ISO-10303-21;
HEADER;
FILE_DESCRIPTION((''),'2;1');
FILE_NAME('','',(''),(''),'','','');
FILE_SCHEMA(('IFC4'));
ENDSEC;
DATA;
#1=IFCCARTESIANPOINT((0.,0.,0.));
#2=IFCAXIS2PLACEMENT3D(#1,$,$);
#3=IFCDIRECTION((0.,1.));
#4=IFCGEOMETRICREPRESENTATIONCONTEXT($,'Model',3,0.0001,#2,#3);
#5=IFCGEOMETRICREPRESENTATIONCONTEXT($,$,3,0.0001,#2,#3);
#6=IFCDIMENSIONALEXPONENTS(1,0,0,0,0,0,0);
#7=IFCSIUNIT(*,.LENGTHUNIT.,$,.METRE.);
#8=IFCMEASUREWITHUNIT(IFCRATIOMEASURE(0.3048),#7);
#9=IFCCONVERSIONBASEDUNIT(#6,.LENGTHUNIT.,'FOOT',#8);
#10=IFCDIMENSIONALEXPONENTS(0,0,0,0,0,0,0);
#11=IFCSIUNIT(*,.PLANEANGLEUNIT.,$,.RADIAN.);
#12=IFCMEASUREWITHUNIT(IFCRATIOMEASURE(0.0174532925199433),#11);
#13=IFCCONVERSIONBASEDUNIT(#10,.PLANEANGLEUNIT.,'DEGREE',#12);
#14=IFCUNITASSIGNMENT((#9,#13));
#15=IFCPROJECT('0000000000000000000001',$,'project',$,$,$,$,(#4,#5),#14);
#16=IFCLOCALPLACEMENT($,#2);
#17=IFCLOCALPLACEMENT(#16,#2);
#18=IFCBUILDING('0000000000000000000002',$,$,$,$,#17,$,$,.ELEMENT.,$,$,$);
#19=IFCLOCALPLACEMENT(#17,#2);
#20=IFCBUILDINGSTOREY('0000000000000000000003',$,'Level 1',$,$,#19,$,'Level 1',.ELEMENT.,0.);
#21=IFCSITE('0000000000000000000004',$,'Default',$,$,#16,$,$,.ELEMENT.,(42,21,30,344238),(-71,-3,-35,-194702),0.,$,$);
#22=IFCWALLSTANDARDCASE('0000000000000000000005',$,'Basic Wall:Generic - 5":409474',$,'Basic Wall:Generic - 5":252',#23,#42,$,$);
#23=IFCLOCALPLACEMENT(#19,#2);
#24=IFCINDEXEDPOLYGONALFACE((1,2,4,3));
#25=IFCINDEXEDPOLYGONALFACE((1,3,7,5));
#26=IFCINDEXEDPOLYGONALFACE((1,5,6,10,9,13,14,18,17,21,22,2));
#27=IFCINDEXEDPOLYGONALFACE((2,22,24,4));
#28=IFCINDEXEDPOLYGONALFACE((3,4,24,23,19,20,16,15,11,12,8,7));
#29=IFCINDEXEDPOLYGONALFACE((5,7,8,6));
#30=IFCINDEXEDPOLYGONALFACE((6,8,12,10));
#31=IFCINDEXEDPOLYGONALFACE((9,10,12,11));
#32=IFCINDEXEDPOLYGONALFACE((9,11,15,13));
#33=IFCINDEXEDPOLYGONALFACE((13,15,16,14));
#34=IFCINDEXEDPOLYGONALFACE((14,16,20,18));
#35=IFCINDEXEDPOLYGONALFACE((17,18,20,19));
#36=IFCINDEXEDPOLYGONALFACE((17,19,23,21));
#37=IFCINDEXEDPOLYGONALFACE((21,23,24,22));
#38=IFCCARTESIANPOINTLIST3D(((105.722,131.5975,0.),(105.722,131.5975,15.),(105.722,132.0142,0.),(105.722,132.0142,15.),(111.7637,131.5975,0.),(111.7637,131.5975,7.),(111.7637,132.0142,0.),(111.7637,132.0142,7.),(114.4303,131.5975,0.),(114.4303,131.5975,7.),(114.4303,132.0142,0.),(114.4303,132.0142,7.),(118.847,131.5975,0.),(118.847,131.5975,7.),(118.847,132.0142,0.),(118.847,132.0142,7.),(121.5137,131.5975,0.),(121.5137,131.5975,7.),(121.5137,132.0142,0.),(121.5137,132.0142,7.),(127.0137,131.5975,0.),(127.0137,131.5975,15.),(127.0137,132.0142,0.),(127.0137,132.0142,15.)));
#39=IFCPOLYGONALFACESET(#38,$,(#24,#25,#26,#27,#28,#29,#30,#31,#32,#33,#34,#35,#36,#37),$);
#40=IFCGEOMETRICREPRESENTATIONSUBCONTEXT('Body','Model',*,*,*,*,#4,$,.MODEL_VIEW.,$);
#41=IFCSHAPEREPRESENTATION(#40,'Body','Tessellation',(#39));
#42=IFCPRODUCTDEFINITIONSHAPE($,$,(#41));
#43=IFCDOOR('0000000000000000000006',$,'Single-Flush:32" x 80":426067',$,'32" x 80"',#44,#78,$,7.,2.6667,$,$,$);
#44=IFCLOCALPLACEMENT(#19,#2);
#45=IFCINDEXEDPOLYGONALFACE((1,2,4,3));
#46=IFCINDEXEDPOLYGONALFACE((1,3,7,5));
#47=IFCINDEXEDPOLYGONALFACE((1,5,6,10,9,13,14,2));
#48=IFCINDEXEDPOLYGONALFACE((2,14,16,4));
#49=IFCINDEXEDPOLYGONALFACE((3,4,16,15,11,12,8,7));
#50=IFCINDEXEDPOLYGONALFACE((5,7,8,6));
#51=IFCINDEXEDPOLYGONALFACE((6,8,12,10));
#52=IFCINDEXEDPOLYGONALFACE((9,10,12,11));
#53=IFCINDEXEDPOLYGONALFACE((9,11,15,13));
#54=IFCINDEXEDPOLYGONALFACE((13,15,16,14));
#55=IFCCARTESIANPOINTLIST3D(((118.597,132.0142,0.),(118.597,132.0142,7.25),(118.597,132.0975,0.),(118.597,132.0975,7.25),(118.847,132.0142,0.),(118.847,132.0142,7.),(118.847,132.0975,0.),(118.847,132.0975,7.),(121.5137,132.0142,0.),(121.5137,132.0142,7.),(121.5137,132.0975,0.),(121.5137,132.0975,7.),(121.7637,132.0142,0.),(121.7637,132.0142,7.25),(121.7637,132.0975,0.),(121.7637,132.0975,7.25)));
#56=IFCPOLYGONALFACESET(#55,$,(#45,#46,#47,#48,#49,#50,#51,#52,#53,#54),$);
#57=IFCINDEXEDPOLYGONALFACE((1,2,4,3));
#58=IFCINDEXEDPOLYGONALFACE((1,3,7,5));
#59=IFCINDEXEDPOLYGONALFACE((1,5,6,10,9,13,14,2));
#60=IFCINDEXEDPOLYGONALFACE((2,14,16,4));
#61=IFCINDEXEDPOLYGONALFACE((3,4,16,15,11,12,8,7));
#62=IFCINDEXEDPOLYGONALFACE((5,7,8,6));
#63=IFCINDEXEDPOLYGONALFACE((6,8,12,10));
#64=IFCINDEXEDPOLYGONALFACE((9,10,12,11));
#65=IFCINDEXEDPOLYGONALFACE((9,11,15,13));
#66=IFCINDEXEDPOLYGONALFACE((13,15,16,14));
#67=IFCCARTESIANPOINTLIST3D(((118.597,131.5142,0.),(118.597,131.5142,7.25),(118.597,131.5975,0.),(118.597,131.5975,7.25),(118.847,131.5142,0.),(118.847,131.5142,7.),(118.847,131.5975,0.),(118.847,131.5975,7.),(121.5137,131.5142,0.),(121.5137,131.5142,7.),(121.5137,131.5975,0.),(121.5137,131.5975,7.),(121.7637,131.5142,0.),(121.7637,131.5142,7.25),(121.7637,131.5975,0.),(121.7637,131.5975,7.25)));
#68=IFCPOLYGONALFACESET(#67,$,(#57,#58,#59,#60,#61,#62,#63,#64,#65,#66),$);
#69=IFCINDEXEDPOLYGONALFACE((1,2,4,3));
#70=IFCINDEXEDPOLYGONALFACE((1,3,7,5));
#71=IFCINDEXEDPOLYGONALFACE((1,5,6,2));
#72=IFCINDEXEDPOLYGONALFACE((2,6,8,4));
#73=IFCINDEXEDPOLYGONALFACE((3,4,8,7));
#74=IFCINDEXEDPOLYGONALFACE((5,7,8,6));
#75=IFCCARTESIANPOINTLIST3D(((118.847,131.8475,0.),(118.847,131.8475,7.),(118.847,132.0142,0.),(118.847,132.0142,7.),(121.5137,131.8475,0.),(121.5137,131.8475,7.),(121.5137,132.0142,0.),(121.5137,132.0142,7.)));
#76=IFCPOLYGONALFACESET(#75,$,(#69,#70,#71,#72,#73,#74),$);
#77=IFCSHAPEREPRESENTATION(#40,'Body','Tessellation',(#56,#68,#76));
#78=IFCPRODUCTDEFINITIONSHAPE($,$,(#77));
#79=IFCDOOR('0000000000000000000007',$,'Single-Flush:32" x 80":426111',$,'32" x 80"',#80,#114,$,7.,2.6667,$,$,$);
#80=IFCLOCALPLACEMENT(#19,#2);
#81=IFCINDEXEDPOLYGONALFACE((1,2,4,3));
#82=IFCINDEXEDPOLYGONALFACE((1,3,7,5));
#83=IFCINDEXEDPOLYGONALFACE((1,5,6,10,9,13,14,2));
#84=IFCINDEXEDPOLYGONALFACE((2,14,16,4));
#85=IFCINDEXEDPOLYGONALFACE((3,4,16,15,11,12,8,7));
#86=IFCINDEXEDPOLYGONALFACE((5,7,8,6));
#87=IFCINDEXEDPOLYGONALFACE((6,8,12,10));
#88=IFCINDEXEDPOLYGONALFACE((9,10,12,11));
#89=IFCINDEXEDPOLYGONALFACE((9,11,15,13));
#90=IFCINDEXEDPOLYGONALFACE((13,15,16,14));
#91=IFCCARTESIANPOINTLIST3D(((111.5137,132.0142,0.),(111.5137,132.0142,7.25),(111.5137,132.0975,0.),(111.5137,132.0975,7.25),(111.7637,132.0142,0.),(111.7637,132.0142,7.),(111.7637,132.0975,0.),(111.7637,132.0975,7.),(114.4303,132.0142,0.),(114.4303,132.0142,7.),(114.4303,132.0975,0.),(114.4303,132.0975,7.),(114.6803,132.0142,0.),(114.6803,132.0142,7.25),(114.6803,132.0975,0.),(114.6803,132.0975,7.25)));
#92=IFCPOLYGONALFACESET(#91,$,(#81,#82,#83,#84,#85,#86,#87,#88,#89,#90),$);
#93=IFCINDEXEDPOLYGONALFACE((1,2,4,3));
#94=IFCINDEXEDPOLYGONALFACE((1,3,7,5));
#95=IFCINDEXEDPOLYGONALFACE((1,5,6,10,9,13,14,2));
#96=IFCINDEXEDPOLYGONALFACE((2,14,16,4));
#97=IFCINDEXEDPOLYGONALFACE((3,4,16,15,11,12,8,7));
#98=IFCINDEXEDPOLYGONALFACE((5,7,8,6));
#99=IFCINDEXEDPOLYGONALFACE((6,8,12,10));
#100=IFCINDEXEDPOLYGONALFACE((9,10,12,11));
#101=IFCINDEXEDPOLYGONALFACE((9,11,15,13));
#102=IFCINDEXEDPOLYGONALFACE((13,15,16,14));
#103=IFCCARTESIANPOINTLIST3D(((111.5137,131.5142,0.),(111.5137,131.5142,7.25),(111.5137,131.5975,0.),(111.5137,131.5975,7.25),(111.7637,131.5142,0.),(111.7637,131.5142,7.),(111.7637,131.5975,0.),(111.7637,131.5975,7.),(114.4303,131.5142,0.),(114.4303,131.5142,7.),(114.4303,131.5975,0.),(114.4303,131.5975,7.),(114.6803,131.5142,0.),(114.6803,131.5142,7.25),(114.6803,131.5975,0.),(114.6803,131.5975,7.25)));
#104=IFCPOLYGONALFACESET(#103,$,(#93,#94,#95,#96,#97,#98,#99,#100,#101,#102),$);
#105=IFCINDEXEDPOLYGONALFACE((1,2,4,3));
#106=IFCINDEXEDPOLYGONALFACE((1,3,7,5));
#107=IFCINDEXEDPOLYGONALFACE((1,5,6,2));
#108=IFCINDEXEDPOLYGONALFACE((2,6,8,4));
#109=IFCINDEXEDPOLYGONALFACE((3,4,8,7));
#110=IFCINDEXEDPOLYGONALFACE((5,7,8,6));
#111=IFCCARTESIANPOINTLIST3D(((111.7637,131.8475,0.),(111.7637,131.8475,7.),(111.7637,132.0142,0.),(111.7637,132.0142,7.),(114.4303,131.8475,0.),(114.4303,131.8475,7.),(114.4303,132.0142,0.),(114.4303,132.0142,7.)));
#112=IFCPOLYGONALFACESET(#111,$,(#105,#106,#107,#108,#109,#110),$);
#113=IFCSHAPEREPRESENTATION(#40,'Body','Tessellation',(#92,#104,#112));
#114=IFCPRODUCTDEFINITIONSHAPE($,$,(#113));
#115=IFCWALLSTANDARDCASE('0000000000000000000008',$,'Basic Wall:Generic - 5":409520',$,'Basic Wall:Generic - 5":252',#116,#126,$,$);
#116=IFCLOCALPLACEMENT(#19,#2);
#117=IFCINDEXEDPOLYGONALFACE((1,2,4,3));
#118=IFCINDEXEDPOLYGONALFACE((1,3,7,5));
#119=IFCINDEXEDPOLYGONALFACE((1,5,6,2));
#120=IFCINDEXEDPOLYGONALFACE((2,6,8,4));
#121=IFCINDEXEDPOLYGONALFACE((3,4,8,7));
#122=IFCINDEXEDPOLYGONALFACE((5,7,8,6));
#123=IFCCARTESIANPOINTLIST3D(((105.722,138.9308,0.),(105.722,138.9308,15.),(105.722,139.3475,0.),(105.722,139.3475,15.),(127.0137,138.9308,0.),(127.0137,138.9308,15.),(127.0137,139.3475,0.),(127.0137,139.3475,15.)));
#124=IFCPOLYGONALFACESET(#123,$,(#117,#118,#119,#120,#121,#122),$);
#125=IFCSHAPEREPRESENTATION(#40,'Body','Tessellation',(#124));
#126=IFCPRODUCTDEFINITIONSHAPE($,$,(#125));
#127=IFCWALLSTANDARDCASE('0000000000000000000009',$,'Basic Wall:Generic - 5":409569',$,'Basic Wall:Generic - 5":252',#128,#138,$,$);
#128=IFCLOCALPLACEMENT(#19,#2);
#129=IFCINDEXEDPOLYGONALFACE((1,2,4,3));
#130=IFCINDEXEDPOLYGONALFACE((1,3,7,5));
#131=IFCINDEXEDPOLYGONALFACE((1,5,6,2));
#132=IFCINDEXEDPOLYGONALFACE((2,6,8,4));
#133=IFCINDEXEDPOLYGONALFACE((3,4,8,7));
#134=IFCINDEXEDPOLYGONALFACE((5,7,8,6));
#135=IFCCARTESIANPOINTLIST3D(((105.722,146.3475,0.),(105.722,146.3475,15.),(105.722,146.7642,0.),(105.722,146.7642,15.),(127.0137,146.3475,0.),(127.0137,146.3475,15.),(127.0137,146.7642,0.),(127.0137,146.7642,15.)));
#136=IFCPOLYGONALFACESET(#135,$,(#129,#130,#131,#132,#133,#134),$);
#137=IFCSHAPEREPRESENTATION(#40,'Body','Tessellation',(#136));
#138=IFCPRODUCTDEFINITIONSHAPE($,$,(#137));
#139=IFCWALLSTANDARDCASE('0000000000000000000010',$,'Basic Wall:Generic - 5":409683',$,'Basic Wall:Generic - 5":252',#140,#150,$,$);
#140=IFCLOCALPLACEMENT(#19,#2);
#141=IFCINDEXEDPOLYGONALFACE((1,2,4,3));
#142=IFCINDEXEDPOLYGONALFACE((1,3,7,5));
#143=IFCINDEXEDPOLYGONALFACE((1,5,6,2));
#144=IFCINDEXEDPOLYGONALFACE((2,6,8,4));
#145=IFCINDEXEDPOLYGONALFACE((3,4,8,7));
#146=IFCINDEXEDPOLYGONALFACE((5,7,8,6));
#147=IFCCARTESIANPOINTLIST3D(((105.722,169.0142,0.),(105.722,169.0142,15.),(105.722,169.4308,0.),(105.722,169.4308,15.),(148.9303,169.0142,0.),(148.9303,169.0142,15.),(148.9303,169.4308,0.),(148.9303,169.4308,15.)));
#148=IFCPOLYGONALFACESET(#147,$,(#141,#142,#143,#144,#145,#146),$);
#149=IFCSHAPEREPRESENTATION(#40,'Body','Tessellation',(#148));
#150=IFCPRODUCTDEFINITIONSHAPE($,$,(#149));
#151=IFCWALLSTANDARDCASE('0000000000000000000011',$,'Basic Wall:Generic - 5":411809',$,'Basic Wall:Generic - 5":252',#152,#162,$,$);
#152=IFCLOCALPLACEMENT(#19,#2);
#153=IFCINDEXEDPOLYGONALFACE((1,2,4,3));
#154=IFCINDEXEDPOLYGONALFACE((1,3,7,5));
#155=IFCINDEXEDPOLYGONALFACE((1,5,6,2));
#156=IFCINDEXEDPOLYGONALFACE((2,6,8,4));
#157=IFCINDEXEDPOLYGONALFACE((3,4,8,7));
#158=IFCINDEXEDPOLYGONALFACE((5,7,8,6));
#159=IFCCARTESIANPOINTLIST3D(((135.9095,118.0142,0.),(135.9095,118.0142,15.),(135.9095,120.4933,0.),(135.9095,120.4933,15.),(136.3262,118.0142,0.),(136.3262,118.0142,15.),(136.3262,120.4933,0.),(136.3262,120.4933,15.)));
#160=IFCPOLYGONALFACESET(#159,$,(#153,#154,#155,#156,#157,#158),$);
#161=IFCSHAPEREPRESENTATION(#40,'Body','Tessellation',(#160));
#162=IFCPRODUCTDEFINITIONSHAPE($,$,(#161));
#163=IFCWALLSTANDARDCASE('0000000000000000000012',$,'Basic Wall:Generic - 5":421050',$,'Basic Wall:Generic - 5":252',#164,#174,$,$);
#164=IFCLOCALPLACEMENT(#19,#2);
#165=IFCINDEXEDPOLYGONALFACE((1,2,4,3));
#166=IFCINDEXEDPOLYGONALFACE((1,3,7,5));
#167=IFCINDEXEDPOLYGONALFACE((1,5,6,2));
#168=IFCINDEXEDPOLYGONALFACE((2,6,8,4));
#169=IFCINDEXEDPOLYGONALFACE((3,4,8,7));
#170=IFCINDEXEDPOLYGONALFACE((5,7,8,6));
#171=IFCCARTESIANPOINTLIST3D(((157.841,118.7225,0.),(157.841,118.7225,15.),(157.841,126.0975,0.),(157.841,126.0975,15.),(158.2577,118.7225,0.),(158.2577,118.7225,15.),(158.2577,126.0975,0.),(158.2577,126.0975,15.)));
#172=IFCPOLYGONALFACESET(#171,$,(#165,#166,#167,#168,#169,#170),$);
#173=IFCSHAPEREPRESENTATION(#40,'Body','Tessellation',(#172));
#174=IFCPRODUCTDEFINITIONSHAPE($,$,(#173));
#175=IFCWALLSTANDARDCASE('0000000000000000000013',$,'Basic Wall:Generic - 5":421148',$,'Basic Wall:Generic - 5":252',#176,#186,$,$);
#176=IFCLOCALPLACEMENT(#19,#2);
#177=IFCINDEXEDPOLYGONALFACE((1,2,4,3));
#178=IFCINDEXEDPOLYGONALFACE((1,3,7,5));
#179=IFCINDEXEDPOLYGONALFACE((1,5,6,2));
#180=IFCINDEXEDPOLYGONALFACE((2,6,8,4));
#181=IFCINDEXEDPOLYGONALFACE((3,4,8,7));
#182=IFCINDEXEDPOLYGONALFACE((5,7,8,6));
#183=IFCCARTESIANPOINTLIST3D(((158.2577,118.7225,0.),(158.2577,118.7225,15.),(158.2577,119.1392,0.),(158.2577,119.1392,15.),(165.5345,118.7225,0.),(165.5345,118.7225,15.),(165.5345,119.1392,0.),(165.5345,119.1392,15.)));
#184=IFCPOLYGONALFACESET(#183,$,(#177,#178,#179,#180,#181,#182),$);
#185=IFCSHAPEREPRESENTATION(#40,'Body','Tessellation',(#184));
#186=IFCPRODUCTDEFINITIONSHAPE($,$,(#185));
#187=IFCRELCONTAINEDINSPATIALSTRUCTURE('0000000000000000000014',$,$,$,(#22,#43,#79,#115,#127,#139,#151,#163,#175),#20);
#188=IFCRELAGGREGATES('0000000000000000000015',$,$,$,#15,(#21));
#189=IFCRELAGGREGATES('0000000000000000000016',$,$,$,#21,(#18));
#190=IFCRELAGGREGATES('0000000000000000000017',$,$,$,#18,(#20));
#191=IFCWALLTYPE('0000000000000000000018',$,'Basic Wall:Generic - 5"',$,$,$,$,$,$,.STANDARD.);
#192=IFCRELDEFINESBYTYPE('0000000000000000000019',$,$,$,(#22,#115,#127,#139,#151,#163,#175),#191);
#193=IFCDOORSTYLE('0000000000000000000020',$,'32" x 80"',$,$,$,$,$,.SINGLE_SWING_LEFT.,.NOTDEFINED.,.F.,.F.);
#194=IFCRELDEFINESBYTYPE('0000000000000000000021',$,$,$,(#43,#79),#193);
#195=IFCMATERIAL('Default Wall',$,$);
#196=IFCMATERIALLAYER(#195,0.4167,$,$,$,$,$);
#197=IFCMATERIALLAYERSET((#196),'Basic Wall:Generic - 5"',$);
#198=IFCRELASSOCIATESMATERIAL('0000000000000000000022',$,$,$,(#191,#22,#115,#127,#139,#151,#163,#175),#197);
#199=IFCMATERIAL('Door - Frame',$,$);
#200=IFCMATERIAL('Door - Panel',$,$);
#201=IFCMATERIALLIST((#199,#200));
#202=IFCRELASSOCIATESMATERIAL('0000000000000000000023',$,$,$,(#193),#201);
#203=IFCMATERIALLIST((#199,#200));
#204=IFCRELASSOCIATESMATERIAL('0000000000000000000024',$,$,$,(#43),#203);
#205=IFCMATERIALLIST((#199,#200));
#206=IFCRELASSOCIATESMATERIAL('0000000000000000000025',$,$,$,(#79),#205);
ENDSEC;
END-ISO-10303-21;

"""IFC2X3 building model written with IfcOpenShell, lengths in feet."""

from ifc_helpers import new_model, entity, si_unit, converted_unit, direction, frame, frame_2d, origin, origin_2d_with_axis, place, context, subcontext, project, spatial, polyline, rectangle, outline, extrude, source, transform, mapped, material, material_list, layer, layer_set, layer_usage, type_object, type_shapes, element, fill, save


model = new_model("IFC2X3")

# Units and contexts
model_context = context("Model", 3, precision=0.0001, world=origin(), true_north=direction((0.0, 1.0)))
context_of_model = context(None, 3, precision=0.0001, world=origin(), true_north=direction((0.0, 1.0)))
body_context = subcontext(model_context, "Body", "Model", "MODEL_VIEW")
ifc_project = project(units=[converted_unit("LENGTHUNIT", "FOOT", entity("IfcRatioMeasure", 0.3048), si_unit("LENGTHUNIT", "METRE"), dimensions=[1, 0, 0, 0, 0, 0, 0]), converted_unit("PLANEANGLEUNIT", "DEGREE", entity("IfcRatioMeasure", 0.0174532925199433), si_unit("PLANEANGLEUNIT", "RADIAN"), dimensions=[0, 0, 0, 0, 0, 0, 0])], contexts=[model_context, context_of_model])

# Site, building, storey
site_placement = place(None, origin())
site = spatial("IfcSite", under=ifc_project, at=site_placement, Name="Default", CompositionType="ELEMENT", RefLatitude=(42, 21, 30, 344238), RefLongitude=(-71, -3, -35, -194702), RefElevation=0.0)
building_placement = place(site_placement, origin())
building = spatial("IfcBuilding", under=site, at=building_placement, CompositionType="ELEMENT")
storey_placement = place(building_placement, origin())
storey = spatial("IfcBuildingStorey", under=building, at=storey_placement, Name="Level 1", LongName="Level 1", CompositionType="ELEMENT", Elevation=0.0)

# Shared definitions
ifc_material_1 = material(Name="Default Wall")

# Shared definitions
ifc_layer_1 = layer(ifc_material_1, 0.4167)
ifc_layer_set_1 = layer_set([ifc_layer_1], Name="Basic Wall:Generic - 5\"")
wall_type_1 = type_object("IfcWallType", Name="Basic Wall:Generic - 5\"", PredefinedType="STANDARD", material=ifc_layer_set_1)
ifc_material_2 = material(Name="Door - Frame")
ifc_material_3 = material(Name="Door - Panel")

# Wall, openings, doors
ifc_layer_usage_1 = layer_usage(ifc_layer_set_1, "AXIS2", "NEGATIVE", 0.2083)
wall_1_placement = place(storey_placement, frame((127.0137, 131.8058, 0.0), z_axis=(0.0, 0.0, 1.0), x_axis=(-1.0, 0.0, 0.0)))
wall_1 = element("IfcWallStandardCase", 1, at=wall_1_placement, inside=storey, type_object=wall_type_1, material=ifc_layer_usage_1, Name="Basic Wall:Generic - 5\":409474", ObjectType="Basic Wall:Generic - 5\":252", context=body_context, shape_type="SweptSolid", body=[
    extrude(rectangle(XDim=21.2917, YDim=0.4167, at=frame_2d((10.6458, 0.0), x_axis=(-1.0, 0.0))), origin(), (0.0, 0.0, 1.0), 15.0),
])
opening_1_placement = place(wall_1_placement, frame((8.1667, 0.2083, 0.0)))
opening_1 = element("IfcOpeningElement", 2, at=opening_1_placement, cuts=wall_1, ObjectType="Opening", context=body_context, shape_type="SweptSolid", body=[
    extrude(rectangle(XDim=2.6667, YDim=7.0, at=frame_2d((3.5, 1.3333), x_axis=(0.0, -1.0))), frame((0.0, 0.0, 0.0), z_axis=(0.0, -1.0, 0.0), x_axis=(0.0, 0.0, 1.0)), (0.0, 0.0, 1.0), 0.4167),
])
opening_2_placement = place(wall_1_placement, frame((15.25, 0.2083, 0.0)))
opening_2 = element("IfcOpeningElement", 3, at=opening_2_placement, cuts=wall_1, ObjectType="Opening", context=body_context, shape_type="SweptSolid", body=[
    extrude(rectangle(XDim=2.6667, YDim=7.0, at=frame_2d((3.5, 1.3333), x_axis=(0.0, -1.0))), frame((0.0, 0.0, 0.0), z_axis=(0.0, -1.0, 0.0), x_axis=(0.0, 0.0, 1.0)), (0.0, 0.0, 1.0), 0.4167),
])
ifc_material_list_1 = material_list([ifc_material_2, ifc_material_3])
ifc_material_list_2 = material_list([ifc_material_2, ifc_material_3])
door_style_1 = type_object("IfcDoorStyle", Name="32\" x 80\"", ConstructionType="NOTDEFINED", OperationType="SINGLE_SWING_LEFT", ParameterTakesPrecedence=False, Sizeable=False, material=ifc_material_list_2)
shared_shape_1 = source(origin(), body_context, "Body", "SweptSolid", [
    extrude(outline(polyline([(-1.5833, -3.6875), (1.5833, -3.6875), (1.5833, 3.5625), (1.3333, 3.5625), (1.3333, -3.4375), (-1.3333, -3.4375), (-1.3333, 3.5625), (-1.5833, 3.5625), (-1.5833, -3.6875)])), frame((1.3333, 0.5, 3.5625), z_axis=(0.0, -1.0, 0.0), x_axis=(-1.0, 0.0, 0.0)), (0.0, 0.0, 1.0), 0.0833),
    extrude(outline(polyline([(-3.6875, -1.5833), (3.5625, -1.5833), (3.5625, -1.3333), (-3.4375, -1.3333), (-3.4375, 1.3333), (3.5625, 1.3333), (3.5625, 1.5833), (-3.6875, 1.5833), (-3.6875, -1.5833)])), frame((1.3333, 0.0, 3.5625), z_axis=(0.0, -1.0, 0.0), x_axis=(0.0, 0.0, -1.0)), (0.0, 0.0, 1.0), 0.0833),
    extrude(rectangle(XDim=2.6667, YDim=0.1667, at=origin_2d_with_axis()), frame((1.3333, 0.3333, 0.0)), (0.0, 0.0, 1.0), 7.0),
])
type_shapes(door_style_1, [shared_shape_1])
door_1_placement = place(opening_1_placement, frame((0.0, 0.0, 0.0), z_axis=(0.0, 0.0, 1.0), x_axis=(-1.0, 0.0, 0.0)))
door_1 = element("IfcDoor", 4, at=door_1_placement, inside=storey, type_object=door_style_1, material=ifc_material_list_1, Name="Single-Flush:32\" x 80\":426067", ObjectType="32\" x 80\"", OverallHeight=7.0, OverallWidth=2.6667, context=body_context, shape_type="MappedRepresentation", body=[
    mapped(shared_shape_1, transform((0.0, 0.0, 0.0), scale=1.0)),
])
fill(opening_1, door_1)
ifc_material_list_3 = material_list([ifc_material_2, ifc_material_3])
door_2_placement = place(opening_2_placement, frame((0.0, 0.0, 0.0), z_axis=(0.0, 0.0, 1.0), x_axis=(-1.0, 0.0, 0.0)))
door_2 = element("IfcDoor", 5, at=door_2_placement, inside=storey, type_object=door_style_1, material=ifc_material_list_3, Name="Single-Flush:32\" x 80\":426111", ObjectType="32\" x 80\"", OverallHeight=7.0, OverallWidth=2.6667, context=body_context, shape_type="MappedRepresentation", body=[
    mapped(shared_shape_1, transform((0.0, 0.0, 0.0), scale=1.0)),
])
fill(opening_2, door_2)

# Walls
ifc_layer_usage_2 = layer_usage(ifc_layer_set_1, "AXIS2", "NEGATIVE", 0.2083)
wall_2_placement = place(storey_placement, frame((127.0137, 139.1392, 0.0), z_axis=(0.0, 0.0, 1.0), x_axis=(-1.0, 0.0, 0.0)))
element("IfcWallStandardCase", 6, at=wall_2_placement, inside=storey, type_object=wall_type_1, material=ifc_layer_usage_2, Name="Basic Wall:Generic - 5\":409520", ObjectType="Basic Wall:Generic - 5\":252", context=body_context, shape_type="SweptSolid", body=[
    extrude(rectangle(XDim=21.2917, YDim=0.4167, at=frame_2d((10.6458, 0.0), x_axis=(-1.0, 0.0))), origin(), (0.0, 0.0, 1.0), 15.0),
])
ifc_layer_usage_3 = layer_usage(ifc_layer_set_1, "AXIS2", "NEGATIVE", 0.2083)
wall_3_placement = place(storey_placement, frame((127.0137, 146.5558, 0.0), z_axis=(0.0, 0.0, 1.0), x_axis=(-1.0, 0.0, 0.0)))
element("IfcWallStandardCase", 7, at=wall_3_placement, inside=storey, type_object=wall_type_1, material=ifc_layer_usage_3, Name="Basic Wall:Generic - 5\":409569", ObjectType="Basic Wall:Generic - 5\":252", context=body_context, shape_type="SweptSolid", body=[
    extrude(rectangle(XDim=21.2917, YDim=0.4167, at=frame_2d((10.6458, 0.0), x_axis=(-1.0, 0.0))), origin(), (0.0, 0.0, 1.0), 15.0),
])
ifc_layer_usage_4 = layer_usage(ifc_layer_set_1, "AXIS2", "NEGATIVE", 0.2083)
wall_4_placement = place(storey_placement, frame((148.9303, 169.2225, 0.0), z_axis=(0.0, 0.0, 1.0), x_axis=(-1.0, 0.0, 0.0)))
element("IfcWallStandardCase", 8, at=wall_4_placement, inside=storey, type_object=wall_type_1, material=ifc_layer_usage_4, Name="Basic Wall:Generic - 5\":409683", ObjectType="Basic Wall:Generic - 5\":252", context=body_context, shape_type="SweptSolid", body=[
    extrude(rectangle(XDim=43.2083, YDim=0.4167, at=frame_2d((21.6042, 0.0), x_axis=(-1.0, 0.0))), origin(), (0.0, 0.0, 1.0), 15.0),
])
ifc_layer_usage_5 = layer_usage(ifc_layer_set_1, "AXIS2", "NEGATIVE", 0.2083)
wall_5_placement = place(storey_placement, frame((136.1178, 120.4933, 0.0), z_axis=(0.0, 0.0, 1.0), x_axis=(0.0, -1.0, 0.0)))
element("IfcWallStandardCase", 9, at=wall_5_placement, inside=storey, type_object=wall_type_1, material=ifc_layer_usage_5, Name="Basic Wall:Generic - 5\":411809", ObjectType="Basic Wall:Generic - 5\":252", context=body_context, shape_type="SweptSolid", body=[
    extrude(rectangle(XDim=2.4792, YDim=0.4167, at=frame_2d((1.2396, 0.0), x_axis=(-1.0, 0.0))), origin(), (0.0, 0.0, 1.0), 15.0),
])
ifc_layer_usage_6 = layer_usage(ifc_layer_set_1, "AXIS2", "NEGATIVE", 0.2083)
wall_6_placement = place(storey_placement, frame((158.0494, 126.0975, 0.0), z_axis=(0.0, 0.0, 1.0), x_axis=(0.0, -1.0, 0.0)))
element("IfcWallStandardCase", 10, at=wall_6_placement, inside=storey, type_object=wall_type_1, material=ifc_layer_usage_6, Name="Basic Wall:Generic - 5\":421050", ObjectType="Basic Wall:Generic - 5\":252", context=body_context, shape_type="SweptSolid", body=[
    extrude(rectangle(XDim=7.375, YDim=0.4167, at=frame_2d((3.6875, 0.0), x_axis=(-1.0, 0.0))), origin(), (0.0, 0.0, 1.0), 15.0),
])
ifc_layer_usage_7 = layer_usage(ifc_layer_set_1, "AXIS2", "NEGATIVE", 0.2083)
wall_7_placement = place(storey_placement, frame((158.2577, 118.9308, 0.0)))
element("IfcWallStandardCase", 11, at=wall_7_placement, inside=storey, type_object=wall_type_1, material=ifc_layer_usage_7, Name="Basic Wall:Generic - 5\":421148", ObjectType="Basic Wall:Generic - 5\":252", context=body_context, shape_type="SweptSolid", body=[
    extrude(rectangle(XDim=7.2768, YDim=0.4167, at=frame_2d((3.6384, 0.0), x_axis=(-1.0, 0.0))), origin(), (0.0, 0.0, 1.0), 15.0),
])

save(model, "model.ifc")
